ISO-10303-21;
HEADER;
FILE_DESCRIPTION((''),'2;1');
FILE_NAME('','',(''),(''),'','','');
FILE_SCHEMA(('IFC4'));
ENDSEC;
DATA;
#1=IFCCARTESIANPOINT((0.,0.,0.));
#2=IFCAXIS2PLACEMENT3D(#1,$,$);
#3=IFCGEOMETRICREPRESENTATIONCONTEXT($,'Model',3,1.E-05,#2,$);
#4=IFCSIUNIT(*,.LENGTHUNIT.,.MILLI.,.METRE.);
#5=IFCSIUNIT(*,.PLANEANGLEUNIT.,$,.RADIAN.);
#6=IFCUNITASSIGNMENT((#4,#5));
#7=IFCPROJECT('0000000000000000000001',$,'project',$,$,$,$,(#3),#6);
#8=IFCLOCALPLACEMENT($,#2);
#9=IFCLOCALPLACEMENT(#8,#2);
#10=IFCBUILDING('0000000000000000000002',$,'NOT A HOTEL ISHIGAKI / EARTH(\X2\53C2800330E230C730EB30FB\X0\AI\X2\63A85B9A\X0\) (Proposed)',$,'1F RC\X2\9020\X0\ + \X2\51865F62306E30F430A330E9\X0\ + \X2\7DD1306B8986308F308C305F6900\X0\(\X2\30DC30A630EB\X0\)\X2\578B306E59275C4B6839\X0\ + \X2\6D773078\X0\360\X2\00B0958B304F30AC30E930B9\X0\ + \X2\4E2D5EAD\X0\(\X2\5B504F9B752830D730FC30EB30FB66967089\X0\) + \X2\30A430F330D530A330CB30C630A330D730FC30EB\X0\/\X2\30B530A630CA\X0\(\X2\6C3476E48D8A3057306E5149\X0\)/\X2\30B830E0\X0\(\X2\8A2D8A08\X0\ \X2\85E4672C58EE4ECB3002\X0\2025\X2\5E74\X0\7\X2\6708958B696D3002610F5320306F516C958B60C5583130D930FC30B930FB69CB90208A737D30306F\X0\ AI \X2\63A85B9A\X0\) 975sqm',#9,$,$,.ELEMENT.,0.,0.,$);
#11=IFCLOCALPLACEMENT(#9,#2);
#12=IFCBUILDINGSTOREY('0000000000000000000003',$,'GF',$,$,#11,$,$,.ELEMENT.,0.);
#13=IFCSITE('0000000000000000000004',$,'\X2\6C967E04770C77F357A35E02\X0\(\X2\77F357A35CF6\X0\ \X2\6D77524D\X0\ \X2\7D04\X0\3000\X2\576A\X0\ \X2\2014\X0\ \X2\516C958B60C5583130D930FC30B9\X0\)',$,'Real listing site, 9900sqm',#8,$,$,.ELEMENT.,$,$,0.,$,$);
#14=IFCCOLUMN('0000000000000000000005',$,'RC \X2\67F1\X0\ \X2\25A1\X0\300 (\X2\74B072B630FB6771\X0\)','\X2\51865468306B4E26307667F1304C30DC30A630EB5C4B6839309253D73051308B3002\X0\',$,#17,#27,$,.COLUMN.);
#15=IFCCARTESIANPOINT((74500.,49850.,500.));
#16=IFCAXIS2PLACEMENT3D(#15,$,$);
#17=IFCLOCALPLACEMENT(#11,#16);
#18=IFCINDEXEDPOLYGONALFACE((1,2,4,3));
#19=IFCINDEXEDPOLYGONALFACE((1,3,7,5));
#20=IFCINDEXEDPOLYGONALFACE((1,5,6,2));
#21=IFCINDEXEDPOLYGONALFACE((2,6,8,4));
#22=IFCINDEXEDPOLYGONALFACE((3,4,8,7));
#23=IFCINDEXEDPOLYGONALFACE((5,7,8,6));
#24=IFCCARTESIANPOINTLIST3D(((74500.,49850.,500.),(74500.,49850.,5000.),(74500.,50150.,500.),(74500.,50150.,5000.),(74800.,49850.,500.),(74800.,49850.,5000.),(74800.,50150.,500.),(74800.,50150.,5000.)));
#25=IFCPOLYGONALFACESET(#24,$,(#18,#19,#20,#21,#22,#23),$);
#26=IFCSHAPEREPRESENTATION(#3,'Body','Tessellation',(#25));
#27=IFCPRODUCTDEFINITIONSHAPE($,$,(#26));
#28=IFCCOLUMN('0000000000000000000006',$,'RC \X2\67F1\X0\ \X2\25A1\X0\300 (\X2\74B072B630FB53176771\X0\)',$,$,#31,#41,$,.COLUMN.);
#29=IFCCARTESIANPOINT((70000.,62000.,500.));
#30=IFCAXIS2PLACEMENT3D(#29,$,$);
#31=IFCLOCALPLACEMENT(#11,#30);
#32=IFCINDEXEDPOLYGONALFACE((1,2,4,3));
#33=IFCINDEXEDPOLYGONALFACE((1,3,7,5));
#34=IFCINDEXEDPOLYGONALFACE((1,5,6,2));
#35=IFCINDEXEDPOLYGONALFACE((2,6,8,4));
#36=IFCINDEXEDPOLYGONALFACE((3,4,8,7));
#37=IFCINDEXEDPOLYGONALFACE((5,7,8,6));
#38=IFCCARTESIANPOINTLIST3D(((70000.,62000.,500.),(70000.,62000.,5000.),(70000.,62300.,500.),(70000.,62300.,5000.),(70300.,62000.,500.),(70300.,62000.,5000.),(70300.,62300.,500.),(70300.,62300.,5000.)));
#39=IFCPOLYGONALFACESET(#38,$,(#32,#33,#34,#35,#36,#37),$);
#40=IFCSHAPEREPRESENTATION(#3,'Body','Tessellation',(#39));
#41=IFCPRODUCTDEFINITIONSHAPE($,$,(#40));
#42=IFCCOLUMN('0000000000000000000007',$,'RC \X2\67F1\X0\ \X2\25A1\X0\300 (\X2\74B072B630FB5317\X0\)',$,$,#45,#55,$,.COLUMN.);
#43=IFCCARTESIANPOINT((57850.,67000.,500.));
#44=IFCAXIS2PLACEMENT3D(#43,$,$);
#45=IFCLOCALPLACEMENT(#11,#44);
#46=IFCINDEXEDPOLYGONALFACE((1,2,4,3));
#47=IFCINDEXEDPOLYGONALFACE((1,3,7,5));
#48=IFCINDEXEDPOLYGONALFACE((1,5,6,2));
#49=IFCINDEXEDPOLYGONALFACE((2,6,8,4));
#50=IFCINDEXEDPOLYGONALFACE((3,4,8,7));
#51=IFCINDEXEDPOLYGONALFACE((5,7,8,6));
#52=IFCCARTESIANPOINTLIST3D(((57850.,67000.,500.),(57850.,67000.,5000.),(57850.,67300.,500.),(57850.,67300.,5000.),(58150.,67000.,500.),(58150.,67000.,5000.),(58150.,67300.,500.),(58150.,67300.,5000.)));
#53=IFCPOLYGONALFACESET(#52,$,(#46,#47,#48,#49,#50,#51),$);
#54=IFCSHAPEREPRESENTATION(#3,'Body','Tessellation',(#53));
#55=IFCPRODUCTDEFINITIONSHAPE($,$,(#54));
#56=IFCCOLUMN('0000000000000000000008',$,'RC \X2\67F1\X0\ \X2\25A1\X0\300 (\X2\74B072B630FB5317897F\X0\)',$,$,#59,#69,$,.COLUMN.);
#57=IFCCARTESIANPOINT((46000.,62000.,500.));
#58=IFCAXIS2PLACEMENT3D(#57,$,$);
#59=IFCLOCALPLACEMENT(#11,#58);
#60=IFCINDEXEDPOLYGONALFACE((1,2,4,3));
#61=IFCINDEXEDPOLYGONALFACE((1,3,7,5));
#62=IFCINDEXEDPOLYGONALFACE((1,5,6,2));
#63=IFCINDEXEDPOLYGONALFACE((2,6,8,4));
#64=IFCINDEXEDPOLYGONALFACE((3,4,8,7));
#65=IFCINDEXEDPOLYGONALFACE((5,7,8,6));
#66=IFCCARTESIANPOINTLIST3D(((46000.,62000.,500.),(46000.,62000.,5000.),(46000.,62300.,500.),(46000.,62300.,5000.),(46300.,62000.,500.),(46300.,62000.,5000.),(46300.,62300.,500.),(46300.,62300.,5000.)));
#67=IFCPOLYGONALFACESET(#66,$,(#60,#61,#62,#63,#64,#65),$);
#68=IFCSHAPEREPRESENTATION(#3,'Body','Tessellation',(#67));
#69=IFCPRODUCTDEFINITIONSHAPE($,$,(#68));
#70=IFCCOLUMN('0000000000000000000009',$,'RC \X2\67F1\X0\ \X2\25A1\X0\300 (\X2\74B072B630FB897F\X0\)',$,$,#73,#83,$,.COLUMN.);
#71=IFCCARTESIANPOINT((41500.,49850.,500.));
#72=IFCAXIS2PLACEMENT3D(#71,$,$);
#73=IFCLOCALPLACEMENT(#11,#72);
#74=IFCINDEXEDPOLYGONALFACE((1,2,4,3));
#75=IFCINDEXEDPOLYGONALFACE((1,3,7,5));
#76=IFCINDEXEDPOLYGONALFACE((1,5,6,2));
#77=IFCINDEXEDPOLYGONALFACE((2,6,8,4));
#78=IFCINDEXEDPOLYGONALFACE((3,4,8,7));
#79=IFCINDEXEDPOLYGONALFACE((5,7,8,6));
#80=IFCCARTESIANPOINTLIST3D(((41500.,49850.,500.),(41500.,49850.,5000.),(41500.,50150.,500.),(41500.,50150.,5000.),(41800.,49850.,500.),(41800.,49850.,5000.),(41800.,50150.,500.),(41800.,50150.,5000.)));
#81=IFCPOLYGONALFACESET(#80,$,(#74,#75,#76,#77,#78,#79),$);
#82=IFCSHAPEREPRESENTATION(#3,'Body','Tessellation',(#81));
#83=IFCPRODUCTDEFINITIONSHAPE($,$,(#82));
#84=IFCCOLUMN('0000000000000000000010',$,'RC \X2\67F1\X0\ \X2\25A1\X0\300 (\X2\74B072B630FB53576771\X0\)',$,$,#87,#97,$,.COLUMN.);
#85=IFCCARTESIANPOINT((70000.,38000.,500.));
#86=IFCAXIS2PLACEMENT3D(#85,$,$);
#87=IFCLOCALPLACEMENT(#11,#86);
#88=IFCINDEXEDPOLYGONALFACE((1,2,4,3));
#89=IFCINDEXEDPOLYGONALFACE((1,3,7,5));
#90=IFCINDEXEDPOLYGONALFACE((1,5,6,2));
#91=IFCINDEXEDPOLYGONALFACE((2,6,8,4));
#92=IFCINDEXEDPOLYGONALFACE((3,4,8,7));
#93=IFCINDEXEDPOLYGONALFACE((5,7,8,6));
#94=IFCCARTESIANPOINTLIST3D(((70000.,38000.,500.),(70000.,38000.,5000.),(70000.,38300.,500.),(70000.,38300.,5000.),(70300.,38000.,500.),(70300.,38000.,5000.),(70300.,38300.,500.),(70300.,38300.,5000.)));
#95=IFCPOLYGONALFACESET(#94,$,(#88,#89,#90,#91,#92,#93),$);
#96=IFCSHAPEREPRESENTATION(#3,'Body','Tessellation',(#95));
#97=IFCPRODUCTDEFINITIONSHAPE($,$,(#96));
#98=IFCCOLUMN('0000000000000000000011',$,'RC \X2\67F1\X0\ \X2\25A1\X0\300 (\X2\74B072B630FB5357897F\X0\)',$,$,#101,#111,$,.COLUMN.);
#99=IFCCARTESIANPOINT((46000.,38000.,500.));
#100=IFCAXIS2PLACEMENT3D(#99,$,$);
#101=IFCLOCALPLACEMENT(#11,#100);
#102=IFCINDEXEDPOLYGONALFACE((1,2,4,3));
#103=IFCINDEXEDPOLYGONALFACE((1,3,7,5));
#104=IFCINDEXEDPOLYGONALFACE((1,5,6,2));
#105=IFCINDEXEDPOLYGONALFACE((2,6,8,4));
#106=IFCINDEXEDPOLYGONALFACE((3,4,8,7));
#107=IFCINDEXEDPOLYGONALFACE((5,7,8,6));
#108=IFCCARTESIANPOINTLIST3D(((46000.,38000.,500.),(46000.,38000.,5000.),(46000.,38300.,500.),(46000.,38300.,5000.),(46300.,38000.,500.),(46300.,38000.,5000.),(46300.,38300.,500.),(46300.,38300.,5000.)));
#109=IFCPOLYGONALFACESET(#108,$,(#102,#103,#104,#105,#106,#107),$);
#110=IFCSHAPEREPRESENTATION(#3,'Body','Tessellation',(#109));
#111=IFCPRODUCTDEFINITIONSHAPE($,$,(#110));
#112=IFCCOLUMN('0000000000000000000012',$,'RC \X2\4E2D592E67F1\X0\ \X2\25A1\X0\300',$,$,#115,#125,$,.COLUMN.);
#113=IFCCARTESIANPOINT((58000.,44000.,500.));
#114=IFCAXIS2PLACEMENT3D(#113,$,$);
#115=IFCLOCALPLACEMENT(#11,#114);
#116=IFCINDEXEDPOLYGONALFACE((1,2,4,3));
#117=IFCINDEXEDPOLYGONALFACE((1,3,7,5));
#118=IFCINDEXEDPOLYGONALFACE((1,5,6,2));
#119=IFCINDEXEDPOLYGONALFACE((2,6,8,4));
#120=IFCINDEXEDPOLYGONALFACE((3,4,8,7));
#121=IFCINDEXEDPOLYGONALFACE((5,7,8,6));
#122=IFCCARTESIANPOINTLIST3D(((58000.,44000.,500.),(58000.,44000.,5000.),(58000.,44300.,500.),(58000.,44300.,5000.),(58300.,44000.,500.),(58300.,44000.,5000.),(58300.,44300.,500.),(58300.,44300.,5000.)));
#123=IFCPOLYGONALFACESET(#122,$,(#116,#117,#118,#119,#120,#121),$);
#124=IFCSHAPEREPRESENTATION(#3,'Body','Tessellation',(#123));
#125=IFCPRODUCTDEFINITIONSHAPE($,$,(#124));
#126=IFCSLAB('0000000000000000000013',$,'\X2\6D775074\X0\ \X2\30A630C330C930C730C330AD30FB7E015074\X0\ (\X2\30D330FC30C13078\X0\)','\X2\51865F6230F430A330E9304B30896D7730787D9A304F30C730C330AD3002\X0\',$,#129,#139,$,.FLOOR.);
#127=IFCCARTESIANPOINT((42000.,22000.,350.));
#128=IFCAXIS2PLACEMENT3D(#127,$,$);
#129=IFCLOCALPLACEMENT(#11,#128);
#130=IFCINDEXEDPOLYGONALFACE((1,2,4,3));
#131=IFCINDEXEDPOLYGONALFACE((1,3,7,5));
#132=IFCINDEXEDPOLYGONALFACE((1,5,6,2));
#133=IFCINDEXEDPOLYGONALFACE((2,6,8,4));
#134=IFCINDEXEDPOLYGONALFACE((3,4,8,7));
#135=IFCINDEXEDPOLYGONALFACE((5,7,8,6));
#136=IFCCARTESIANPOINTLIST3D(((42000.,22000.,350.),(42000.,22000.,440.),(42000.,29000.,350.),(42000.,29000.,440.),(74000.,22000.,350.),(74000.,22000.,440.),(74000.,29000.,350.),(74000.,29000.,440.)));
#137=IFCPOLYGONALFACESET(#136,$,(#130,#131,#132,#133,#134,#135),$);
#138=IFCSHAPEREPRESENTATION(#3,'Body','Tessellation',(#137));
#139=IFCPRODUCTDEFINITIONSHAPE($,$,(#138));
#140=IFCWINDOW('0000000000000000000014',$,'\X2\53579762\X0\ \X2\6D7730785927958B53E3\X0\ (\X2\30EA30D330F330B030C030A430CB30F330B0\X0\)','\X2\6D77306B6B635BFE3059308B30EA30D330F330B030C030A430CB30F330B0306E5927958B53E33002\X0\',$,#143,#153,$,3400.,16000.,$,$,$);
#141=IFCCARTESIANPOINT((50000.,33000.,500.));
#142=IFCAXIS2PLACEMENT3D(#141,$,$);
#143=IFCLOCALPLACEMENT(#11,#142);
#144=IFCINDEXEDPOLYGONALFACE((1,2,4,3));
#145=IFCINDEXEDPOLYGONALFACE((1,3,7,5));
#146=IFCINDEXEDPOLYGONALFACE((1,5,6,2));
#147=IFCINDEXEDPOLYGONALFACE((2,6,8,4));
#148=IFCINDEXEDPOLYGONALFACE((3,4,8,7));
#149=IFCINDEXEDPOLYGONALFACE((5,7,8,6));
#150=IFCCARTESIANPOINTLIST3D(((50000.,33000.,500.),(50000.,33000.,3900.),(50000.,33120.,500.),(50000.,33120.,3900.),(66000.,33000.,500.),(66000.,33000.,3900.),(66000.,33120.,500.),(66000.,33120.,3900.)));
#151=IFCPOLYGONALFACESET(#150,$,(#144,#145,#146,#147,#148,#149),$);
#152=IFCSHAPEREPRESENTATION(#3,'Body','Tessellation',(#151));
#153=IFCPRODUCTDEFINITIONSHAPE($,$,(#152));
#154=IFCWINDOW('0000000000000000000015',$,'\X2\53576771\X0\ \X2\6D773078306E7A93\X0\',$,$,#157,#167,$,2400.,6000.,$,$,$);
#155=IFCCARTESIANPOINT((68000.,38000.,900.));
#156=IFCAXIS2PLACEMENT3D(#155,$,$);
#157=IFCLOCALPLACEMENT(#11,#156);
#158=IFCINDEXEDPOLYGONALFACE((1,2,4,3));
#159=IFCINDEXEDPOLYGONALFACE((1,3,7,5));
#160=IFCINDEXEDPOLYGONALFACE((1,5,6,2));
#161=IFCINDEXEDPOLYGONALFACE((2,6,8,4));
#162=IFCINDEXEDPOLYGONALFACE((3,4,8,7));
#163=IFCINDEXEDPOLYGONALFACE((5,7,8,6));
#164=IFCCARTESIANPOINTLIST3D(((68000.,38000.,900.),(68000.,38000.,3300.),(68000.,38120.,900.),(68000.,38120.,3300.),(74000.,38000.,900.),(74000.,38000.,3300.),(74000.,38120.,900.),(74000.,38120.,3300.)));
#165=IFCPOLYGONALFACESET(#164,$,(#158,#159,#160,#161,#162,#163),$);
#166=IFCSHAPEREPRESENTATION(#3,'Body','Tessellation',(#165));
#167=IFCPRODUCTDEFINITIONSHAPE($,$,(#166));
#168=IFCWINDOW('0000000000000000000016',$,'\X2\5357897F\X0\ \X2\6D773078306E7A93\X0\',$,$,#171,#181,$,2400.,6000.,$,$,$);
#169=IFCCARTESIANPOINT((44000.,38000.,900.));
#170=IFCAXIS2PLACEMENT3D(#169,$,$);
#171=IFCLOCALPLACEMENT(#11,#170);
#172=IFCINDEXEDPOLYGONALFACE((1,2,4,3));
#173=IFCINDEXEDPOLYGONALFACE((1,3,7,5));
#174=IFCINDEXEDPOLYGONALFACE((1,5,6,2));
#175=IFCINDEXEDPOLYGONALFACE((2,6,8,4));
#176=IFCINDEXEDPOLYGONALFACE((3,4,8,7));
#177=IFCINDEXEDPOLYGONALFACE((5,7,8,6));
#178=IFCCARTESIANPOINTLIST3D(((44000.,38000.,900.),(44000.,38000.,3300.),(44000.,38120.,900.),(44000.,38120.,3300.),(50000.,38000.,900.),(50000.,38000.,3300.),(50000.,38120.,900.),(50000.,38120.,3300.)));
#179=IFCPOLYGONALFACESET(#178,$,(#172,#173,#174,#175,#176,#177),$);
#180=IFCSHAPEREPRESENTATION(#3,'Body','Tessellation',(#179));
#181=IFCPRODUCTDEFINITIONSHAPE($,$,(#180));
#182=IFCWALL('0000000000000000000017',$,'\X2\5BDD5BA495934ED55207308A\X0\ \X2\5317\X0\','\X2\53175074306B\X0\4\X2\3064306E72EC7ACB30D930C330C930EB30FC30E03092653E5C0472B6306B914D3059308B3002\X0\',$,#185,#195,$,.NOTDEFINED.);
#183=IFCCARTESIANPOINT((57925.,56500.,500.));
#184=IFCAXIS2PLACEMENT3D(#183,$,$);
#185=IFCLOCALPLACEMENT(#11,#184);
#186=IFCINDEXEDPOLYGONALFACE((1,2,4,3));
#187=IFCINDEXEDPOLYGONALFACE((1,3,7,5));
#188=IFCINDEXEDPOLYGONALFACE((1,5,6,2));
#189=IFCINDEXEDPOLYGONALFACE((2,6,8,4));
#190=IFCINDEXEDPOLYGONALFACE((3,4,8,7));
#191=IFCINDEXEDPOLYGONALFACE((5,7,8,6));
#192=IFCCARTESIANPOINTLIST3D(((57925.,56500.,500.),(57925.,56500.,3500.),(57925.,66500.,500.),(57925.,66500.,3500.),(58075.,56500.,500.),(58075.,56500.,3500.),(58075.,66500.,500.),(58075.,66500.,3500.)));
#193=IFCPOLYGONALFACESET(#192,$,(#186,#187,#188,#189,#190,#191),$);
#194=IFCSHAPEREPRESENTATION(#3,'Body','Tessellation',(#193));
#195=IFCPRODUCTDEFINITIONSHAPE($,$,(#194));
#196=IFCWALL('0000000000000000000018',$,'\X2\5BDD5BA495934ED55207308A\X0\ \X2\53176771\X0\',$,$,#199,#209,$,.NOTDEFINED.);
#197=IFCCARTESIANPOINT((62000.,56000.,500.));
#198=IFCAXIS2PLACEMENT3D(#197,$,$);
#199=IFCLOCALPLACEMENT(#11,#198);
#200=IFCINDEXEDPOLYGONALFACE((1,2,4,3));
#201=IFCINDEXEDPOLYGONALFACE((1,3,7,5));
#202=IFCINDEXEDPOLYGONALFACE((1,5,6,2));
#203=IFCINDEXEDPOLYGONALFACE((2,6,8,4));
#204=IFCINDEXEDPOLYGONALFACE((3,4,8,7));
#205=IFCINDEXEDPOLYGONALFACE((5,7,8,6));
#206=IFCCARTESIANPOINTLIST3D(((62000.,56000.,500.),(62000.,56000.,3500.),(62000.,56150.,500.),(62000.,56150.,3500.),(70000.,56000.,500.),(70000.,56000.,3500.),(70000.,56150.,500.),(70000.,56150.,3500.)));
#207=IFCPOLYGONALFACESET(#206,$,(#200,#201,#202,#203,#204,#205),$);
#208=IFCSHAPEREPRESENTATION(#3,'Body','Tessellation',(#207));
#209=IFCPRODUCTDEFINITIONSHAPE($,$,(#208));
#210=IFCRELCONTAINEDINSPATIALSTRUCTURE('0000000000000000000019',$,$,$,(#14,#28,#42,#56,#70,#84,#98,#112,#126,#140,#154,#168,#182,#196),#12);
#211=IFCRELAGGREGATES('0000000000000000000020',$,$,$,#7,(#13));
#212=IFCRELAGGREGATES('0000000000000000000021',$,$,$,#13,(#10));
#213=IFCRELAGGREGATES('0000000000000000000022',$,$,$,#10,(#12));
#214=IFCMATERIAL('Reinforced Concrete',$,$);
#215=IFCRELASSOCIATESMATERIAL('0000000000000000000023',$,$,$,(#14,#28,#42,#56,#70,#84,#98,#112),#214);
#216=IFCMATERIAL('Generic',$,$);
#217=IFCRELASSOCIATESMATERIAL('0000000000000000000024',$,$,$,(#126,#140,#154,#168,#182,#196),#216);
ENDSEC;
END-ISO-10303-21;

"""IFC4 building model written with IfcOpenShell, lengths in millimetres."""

from ifc_helpers import new_model, si_unit, frame, frame_2d, origin, place, context, project, spatial, rectangle, extrude, material, element, save


model = new_model("IFC4")

# Units and contexts
model_context = context("Model", 3, precision=1e-05, world=origin())
ifc_project = project(units=[si_unit("LENGTHUNIT", "METRE", prefix="MILLI"), si_unit("PLANEANGLEUNIT", "RADIAN")], contexts=[model_context])

# Site, building, storey
site_placement = place(None, origin())
site = spatial("IfcSite", under=ifc_project, at=site_placement, Name="沖縄県石垣市(石垣島 海前 約3000坪 — 公開情報ベース)", ObjectType="Real listing site, 9900sqm", CompositionType="ELEMENT", RefElevation=0.0)
building_placement = place(site_placement, origin())
building = spatial("IfcBuilding", under=site, at=building_placement, Name="NOT A HOTEL ISHIGAKI / EARTH(参考モデル・AI推定) (Proposed)", ObjectType="1F RC造 + 円形のヴィラ + 緑に覆われた椀(ボウル)型の大屋根 + 海へ360°開くガラス + 中庭(子供用プール・暖炉) + インフィニティプール/サウナ(水盤越しの光)/ジム(設計 藤本壮介。2025年7月開業。意匠は公開情報ベース・構造詳細は AI 推定) 975sqm", CompositionType="ELEMENT", ElevationOfRefHeight=0.0, ElevationOfTerrain=0.0)
storey_placement = place(building_placement, origin())
storey = spatial("IfcBuildingStorey", under=building, at=storey_placement, Name="GF", CompositionType="ELEMENT", Elevation=0.0)

# Columns
ifc_material_1 = material(Name="Reinforced Concrete")
column_1_placement = place(storey_placement, frame((74500.0, 49850.0, 500.0)))
element("IfcColumn", 1, at=column_1_placement, inside=storey, material=ifc_material_1, Name="RC 柱 □300 (環状・東)", Description="円周に並ぶ柱がボウル屋根を受ける。", PredefinedType="COLUMN", context=model_context, shape_type="SweptSolid", body=[
    extrude(rectangle(XDim=300.0, YDim=300.0, at=frame_2d((150.0, 150.0))), frame((74500.0, 49850.0, 500.0)), (0.0, 0.0, 1.0), 4500.0),
])
column_2_placement = place(storey_placement, frame((70000.0, 62000.0, 500.0)))
element("IfcColumn", 2, at=column_2_placement, inside=storey, material=ifc_material_1, Name="RC 柱 □300 (環状・北東)", PredefinedType="COLUMN", context=model_context, shape_type="SweptSolid", body=[
    extrude(rectangle(XDim=300.0, YDim=300.0, at=frame_2d((150.0, 150.0))), frame((70000.0, 62000.0, 500.0)), (0.0, 0.0, 1.0), 4500.0),
])
column_3_placement = place(storey_placement, frame((57850.0, 67000.0, 500.0)))
element("IfcColumn", 3, at=column_3_placement, inside=storey, material=ifc_material_1, Name="RC 柱 □300 (環状・北)", PredefinedType="COLUMN", context=model_context, shape_type="SweptSolid", body=[
    extrude(rectangle(XDim=300.0, YDim=300.0, at=frame_2d((150.0, 150.0))), frame((57850.0, 67000.0, 500.0)), (0.0, 0.0, 1.0), 4500.0),
])
column_4_placement = place(storey_placement, frame((46000.0, 62000.0, 500.0)))
element("IfcColumn", 4, at=column_4_placement, inside=storey, material=ifc_material_1, Name="RC 柱 □300 (環状・北西)", PredefinedType="COLUMN", context=model_context, shape_type="SweptSolid", body=[
    extrude(rectangle(XDim=300.0, YDim=300.0, at=frame_2d((150.0, 150.0))), frame((46000.0, 62000.0, 500.0)), (0.0, 0.0, 1.0), 4500.0),
])
column_5_placement = place(storey_placement, frame((41500.0, 49850.0, 500.0)))
element("IfcColumn", 5, at=column_5_placement, inside=storey, material=ifc_material_1, Name="RC 柱 □300 (環状・西)", PredefinedType="COLUMN", context=model_context, shape_type="SweptSolid", body=[
    extrude(rectangle(XDim=300.0, YDim=300.0, at=frame_2d((150.0, 150.0))), frame((41500.0, 49850.0, 500.0)), (0.0, 0.0, 1.0), 4500.0),
])
column_6_placement = place(storey_placement, frame((70000.0, 38000.0, 500.0)))
element("IfcColumn", 6, at=column_6_placement, inside=storey, material=ifc_material_1, Name="RC 柱 □300 (環状・南東)", PredefinedType="COLUMN", context=model_context, shape_type="SweptSolid", body=[
    extrude(rectangle(XDim=300.0, YDim=300.0, at=frame_2d((150.0, 150.0))), frame((70000.0, 38000.0, 500.0)), (0.0, 0.0, 1.0), 4500.0),
])
column_7_placement = place(storey_placement, frame((46000.0, 38000.0, 500.0)))
element("IfcColumn", 7, at=column_7_placement, inside=storey, material=ifc_material_1, Name="RC 柱 □300 (環状・南西)", PredefinedType="COLUMN", context=model_context, shape_type="SweptSolid", body=[
    extrude(rectangle(XDim=300.0, YDim=300.0, at=frame_2d((150.0, 150.0))), frame((46000.0, 38000.0, 500.0)), (0.0, 0.0, 1.0), 4500.0),
])
column_8_placement = place(storey_placement, frame((58000.0, 44000.0, 500.0)))
element("IfcColumn", 8, at=column_8_placement, inside=storey, material=ifc_material_1, Name="RC 中央柱 □300", PredefinedType="COLUMN", context=model_context, shape_type="SweptSolid", body=[
    extrude(rectangle(XDim=300.0, YDim=300.0, at=frame_2d((150.0, 150.0))), frame((58000.0, 44000.0, 500.0)), (0.0, 0.0, 1.0), 4500.0),
])

# Slab
ifc_material_2 = material(Name="Generic")
slab_1_placement = place(storey_placement, frame((42000.0, 22000.0, 350.0)))
element("IfcSlab", 9, at=slab_1_placement, inside=storey, material=ifc_material_2, Name="海側 ウッドデッキ・縁側 (ビーチへ)", Description="円形ヴィラから海へ続くデッキ。", PredefinedType="FLOOR", context=model_context, shape_type="SweptSolid", body=[
    extrude(rectangle(XDim=32000.0, YDim=7000.0, at=frame_2d((16000.0, 3500.0))), frame((42000.0, 22000.0, 350.0)), (0.0, 0.0, 1.0), 90.0),
])

# Windows
window_1_placement = place(storey_placement, frame((50000.0, 33000.0, 500.0)))
element("IfcWindow", 10, at=window_1_placement, inside=storey, material=ifc_material_2, Name="南面 海へ大開口 (リビングダイニング)", Description="海に正対するリビングダイニングの大開口。", OverallHeight=3400.0, OverallWidth=16000.0, context=model_context, shape_type="SweptSolid", body=[
    extrude(rectangle(XDim=16000.0, YDim=120.0, at=frame_2d((8000.0, 60.0))), frame((50000.0, 33000.0, 500.0)), (0.0, 0.0, 1.0), 3400.0),
])
window_2_placement = place(storey_placement, frame((68000.0, 38000.0, 900.0)))
element("IfcWindow", 11, at=window_2_placement, inside=storey, material=ifc_material_2, Name="南東 海への窓", OverallHeight=2400.0, OverallWidth=6000.0, context=model_context, shape_type="SweptSolid", body=[
    extrude(rectangle(XDim=6000.0, YDim=120.0, at=frame_2d((3000.0, 60.0))), frame((68000.0, 38000.0, 900.0)), (0.0, 0.0, 1.0), 2400.0),
])
window_3_placement = place(storey_placement, frame((44000.0, 38000.0, 900.0)))
element("IfcWindow", 12, at=window_3_placement, inside=storey, material=ifc_material_2, Name="南西 海への窓", OverallHeight=2400.0, OverallWidth=6000.0, context=model_context, shape_type="SweptSolid", body=[
    extrude(rectangle(XDim=6000.0, YDim=120.0, at=frame_2d((3000.0, 60.0))), frame((44000.0, 38000.0, 900.0)), (0.0, 0.0, 1.0), 2400.0),
])

# Walls
wall_1_placement = place(storey_placement, frame((57925.0, 56500.0, 500.0)))
element("IfcWall", 13, at=wall_1_placement, inside=storey, material=ifc_material_2, Name="寝室間仕切り 北", Description="北側に4つの独立ベッドルームを放射状に配する。", PredefinedType="NOTDEFINED", context=model_context, shape_type="SweptSolid", body=[
    extrude(rectangle(XDim=150.0, YDim=10000.0, at=frame_2d((75.0, 5000.0))), frame((57925.0, 56500.0, 500.0)), (0.0, 0.0, 1.0), 3000.0),
])
wall_2_placement = place(storey_placement, frame((62000.0, 56000.0, 500.0)))
element("IfcWall", 14, at=wall_2_placement, inside=storey, material=ifc_material_2, Name="寝室間仕切り 北東", PredefinedType="NOTDEFINED", context=model_context, shape_type="SweptSolid", body=[
    extrude(rectangle(XDim=8000.0, YDim=150.0, at=frame_2d((4000.0, 75.0))), frame((62000.0, 56000.0, 500.0)), (0.0, 0.0, 1.0), 3000.0),
])

save(model, "model.ifc")
